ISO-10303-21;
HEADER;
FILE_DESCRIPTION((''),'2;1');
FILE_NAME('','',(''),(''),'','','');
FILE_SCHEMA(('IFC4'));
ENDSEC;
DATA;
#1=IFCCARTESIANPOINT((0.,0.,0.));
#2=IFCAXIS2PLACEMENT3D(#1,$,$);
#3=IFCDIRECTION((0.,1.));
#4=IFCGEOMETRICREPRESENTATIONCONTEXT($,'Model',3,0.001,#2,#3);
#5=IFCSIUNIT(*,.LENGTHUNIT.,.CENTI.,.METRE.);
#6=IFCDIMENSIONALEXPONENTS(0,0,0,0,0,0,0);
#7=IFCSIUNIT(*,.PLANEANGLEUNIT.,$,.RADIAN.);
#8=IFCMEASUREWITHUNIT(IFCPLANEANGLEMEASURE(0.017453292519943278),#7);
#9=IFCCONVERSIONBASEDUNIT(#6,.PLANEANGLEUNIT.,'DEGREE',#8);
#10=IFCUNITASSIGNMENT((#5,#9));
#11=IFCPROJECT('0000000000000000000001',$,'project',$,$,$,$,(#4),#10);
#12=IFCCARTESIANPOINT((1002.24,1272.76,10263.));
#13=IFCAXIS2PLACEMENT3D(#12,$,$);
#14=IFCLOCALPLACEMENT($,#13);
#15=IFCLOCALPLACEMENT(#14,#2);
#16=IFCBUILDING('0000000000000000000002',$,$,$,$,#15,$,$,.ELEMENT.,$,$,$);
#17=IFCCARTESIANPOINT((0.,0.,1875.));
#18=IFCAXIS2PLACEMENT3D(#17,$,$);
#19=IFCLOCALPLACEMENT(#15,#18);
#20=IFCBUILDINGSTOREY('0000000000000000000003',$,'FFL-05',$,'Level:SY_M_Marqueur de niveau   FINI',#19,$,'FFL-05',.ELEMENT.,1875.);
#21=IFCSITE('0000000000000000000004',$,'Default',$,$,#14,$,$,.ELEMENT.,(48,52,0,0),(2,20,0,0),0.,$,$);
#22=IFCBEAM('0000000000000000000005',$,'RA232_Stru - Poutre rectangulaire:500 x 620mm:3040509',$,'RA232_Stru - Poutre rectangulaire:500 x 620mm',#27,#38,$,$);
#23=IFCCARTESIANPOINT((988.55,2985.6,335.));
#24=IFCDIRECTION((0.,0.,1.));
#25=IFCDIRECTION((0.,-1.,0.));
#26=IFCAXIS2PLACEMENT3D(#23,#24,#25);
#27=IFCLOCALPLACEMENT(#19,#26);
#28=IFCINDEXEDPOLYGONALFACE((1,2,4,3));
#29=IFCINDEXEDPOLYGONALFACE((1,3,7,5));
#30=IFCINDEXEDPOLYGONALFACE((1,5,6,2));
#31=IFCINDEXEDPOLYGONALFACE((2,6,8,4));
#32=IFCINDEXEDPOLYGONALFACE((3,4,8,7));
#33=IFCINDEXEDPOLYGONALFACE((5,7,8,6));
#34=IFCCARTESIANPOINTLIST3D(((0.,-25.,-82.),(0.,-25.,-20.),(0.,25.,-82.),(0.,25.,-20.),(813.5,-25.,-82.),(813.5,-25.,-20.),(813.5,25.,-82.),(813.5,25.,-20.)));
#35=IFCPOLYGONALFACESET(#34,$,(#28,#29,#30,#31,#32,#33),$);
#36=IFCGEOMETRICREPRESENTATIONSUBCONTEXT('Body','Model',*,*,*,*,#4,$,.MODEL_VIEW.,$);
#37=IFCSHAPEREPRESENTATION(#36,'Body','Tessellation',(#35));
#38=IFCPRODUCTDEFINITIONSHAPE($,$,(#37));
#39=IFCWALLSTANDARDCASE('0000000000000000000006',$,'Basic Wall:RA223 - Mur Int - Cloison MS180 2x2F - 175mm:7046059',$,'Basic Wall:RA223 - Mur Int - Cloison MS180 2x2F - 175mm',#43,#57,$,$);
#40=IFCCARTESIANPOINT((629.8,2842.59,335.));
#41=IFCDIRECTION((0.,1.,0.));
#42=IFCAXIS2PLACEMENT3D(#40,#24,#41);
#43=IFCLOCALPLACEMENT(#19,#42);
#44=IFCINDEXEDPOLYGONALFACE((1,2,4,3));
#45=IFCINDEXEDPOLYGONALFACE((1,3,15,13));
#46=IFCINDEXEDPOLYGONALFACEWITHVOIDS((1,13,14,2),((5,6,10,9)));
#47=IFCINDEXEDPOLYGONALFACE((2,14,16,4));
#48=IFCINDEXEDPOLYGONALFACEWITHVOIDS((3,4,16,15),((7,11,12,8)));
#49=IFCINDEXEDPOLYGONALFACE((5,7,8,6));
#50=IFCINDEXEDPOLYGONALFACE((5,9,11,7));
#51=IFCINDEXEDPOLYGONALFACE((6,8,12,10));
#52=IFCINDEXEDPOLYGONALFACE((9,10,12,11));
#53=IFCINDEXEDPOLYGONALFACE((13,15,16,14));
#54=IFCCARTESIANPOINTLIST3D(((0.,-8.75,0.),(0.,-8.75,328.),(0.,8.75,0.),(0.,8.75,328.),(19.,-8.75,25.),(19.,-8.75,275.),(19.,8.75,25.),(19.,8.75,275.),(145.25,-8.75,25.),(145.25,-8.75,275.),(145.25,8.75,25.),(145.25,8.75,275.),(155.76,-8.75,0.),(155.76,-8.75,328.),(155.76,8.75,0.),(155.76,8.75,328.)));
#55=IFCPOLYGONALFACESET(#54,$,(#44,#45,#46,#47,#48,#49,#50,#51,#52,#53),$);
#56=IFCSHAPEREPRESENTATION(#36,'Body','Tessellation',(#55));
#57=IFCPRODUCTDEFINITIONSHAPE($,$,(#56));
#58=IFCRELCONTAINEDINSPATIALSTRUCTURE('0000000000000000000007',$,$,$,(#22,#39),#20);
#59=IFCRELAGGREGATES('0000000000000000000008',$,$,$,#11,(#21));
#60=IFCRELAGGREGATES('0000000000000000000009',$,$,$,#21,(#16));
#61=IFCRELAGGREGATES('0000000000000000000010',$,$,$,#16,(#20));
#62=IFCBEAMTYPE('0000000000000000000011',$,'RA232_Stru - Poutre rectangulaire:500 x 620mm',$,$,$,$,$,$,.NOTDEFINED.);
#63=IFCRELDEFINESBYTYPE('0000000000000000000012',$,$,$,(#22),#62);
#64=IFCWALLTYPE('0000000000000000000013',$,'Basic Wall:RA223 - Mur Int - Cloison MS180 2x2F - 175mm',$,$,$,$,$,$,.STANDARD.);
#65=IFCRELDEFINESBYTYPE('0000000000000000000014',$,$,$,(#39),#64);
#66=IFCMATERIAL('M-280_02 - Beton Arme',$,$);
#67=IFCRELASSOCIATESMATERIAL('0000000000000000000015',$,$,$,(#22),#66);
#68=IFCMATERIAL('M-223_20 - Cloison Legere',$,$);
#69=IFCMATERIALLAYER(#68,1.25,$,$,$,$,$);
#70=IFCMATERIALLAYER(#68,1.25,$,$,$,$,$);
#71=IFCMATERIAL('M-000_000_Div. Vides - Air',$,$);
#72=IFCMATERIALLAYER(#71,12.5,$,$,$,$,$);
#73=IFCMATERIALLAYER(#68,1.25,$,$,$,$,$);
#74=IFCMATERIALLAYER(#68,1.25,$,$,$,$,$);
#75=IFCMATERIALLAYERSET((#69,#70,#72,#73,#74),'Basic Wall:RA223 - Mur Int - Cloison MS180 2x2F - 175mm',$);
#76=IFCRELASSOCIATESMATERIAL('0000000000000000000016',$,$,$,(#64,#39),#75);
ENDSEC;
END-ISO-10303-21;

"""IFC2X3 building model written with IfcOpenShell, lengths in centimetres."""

from ifc_helpers import new_model, entity, si_unit, converted_unit, direction, frame, frame_2d, origin, place, context, subcontext, project, spatial, polyline, rectangle, extrude, clip, bounded_halfspace, material, layer, layer_set, layer_usage, type_object, element, save


model = new_model("IFC2X3")

# Units and contexts
model_context = context("Model", 3, precision=0.001, world=origin(), true_north=direction((0.0, 1.0)))
body_context = subcontext(model_context, "Body", "Model", "MODEL_VIEW")
ifc_project = project(units=[si_unit("LENGTHUNIT", "METRE", prefix="CENTI"), converted_unit("PLANEANGLEUNIT", "DEGREE", entity("IfcPlaneAngleMeasure", 0.017453292519943278), si_unit("PLANEANGLEUNIT", "RADIAN"), dimensions=[0, 0, 0, 0, 0, 0, 0])], contexts=[model_context])

# Site, building, storey
site_placement = place(None, frame((1002.24, 1272.76, 10263.0)))
site = spatial("IfcSite", under=ifc_project, at=site_placement, Name="Default", CompositionType="ELEMENT", RefLatitude=(48, 52, 0, 0), RefLongitude=(2, 20, 0, 0), RefElevation=0.0)
building_placement = place(site_placement, origin())
building = spatial("IfcBuilding", under=site, at=building_placement, CompositionType="ELEMENT")
storey_placement = place(building_placement, frame((0.0, 0.0, 1875.0)))
storey = spatial("IfcBuildingStorey", under=building, at=storey_placement, Name="FFL-05", ObjectType="Level:SY_M_Marqueur de niveau   FINI", LongName="FFL-05", CompositionType="ELEMENT", Elevation=1875.0)

# Beam
ifc_material_1 = material(Name="M-280_02 - Beton Arme")
beam_type = type_object("IfcBeamType", Name="RA232_Stru - Poutre rectangulaire:500 x 620mm", PredefinedType="NOTDEFINED")
beam_placement = place(storey_placement, frame((988.55, 2985.6, 335.0), z_axis=(0.0, 0.0, 1.0), x_axis=(0.0, -1.0, 0.0)))
element("IfcBeam", 1, at=beam_placement, inside=storey, type_object=beam_type, material=ifc_material_1, Name="RA232_Stru - Poutre rectangulaire:500 x 620mm:3040509", ObjectType="RA232_Stru - Poutre rectangulaire:500 x 620mm", context=body_context, shape_type="SweptSolid", body=[
    extrude(rectangle(XDim=62.0, YDim=50.0, at=frame_2d((0.0, 0.0), x_axis=(1.0, 0.0))), frame((0.0, 0.0, -51.0), z_axis=(1.0, 0.0, 0.0), x_axis=(0.0, 0.0, -1.0)), (0.0, 0.0, 1.0), 813.5),
])

# Shared definitions
ifc_material_2 = material(Name="M-223_20 - Cloison Legere")
ifc_layer_1 = layer(ifc_material_2, 1.25)
ifc_layer_2 = layer(ifc_material_2, 1.25)
ifc_material_3 = material(Name="M-000_000_Div. Vides - Air")
ifc_layer_3 = layer(ifc_material_3, 12.5)
ifc_layer_4 = layer(ifc_material_2, 1.25)
ifc_layer_5 = layer(ifc_material_2, 1.25)
ifc_layer_set_1 = layer_set([ifc_layer_1, ifc_layer_2, ifc_layer_3, ifc_layer_4, ifc_layer_5], Name="Basic Wall:RA223 - Mur Int - Cloison MS180 2x2F - 175mm")
wall_type_1 = type_object("IfcWallType", Name="Basic Wall:RA223 - Mur Int - Cloison MS180 2x2F - 175mm", PredefinedType="STANDARD", material=ifc_layer_set_1)

# Wall, opening
ifc_layer_usage_1 = layer_usage(ifc_layer_set_1, "AXIS2", "POSITIVE", -8.75)
wall_1_placement = place(storey_placement, frame((629.8, 2842.59, 335.0), z_axis=(0.0, 0.0, 1.0), x_axis=(0.0, 1.0, 0.0)))
wall_1 = element("IfcWallStandardCase", 2, at=wall_1_placement, inside=storey, type_object=wall_type_1, material=ifc_layer_usage_1, Name="Basic Wall:RA223 - Mur Int - Cloison MS180 2x2F - 175mm:7046059", ObjectType="Basic Wall:RA223 - Mur Int - Cloison MS180 2x2F - 175mm", context=body_context, shape_type="Clipping", body=[
    clip(clip(extrude(rectangle(XDim=155.76, YDim=17.5, at=frame_2d((77.88, 0.0), x_axis=(-1.0, 0.0))), origin(), (0.0, 0.0, 1.0), 328.0), bounded_halfspace(frame((0.0, 8.75, 328.0), z_axis=(0.0, 0.0, -1.0), x_axis=(0.0, -1.0, 0.0)), True, frame((0.0, 8.75, 328.0)), polyline([(0.0, 0.0), (0.0, -17.5), (143.01, -17.5), (143.01, 0.0), (17.5, 0.0), (0.0, 0.0)]))), bounded_halfspace(frame((0.0, -8.75, 0.0), z_axis=(0.0, 0.0, 1.0), x_axis=(0.0, 1.0, 0.0)), True, frame((0.0, -8.75, 0.0)), polyline([(0.0, 0.0), (143.01, 0.0), (143.01, 17.5), (17.5, 17.5), (0.0, 17.5), (0.0, 0.0)]))),
])
opening_1_placement = place(wall_1_placement, origin())
element("IfcOpeningElement", 3, at=opening_1_placement, cuts=wall_1, ObjectType="Opening", context=body_context, shape_type="SweptSolid", body=[
    extrude(rectangle(XDim=250.0, YDim=126.25, at=frame_2d((0.0, 0.0), x_axis=(1.0, 0.0))), frame((82.12, -23.99, 150.0), z_axis=(0.0, 1.0, 0.0), x_axis=(0.0, 0.0, 1.0)), (0.0, 0.0, 1.0), 47.98),
])

save(model, "model.ifc")
